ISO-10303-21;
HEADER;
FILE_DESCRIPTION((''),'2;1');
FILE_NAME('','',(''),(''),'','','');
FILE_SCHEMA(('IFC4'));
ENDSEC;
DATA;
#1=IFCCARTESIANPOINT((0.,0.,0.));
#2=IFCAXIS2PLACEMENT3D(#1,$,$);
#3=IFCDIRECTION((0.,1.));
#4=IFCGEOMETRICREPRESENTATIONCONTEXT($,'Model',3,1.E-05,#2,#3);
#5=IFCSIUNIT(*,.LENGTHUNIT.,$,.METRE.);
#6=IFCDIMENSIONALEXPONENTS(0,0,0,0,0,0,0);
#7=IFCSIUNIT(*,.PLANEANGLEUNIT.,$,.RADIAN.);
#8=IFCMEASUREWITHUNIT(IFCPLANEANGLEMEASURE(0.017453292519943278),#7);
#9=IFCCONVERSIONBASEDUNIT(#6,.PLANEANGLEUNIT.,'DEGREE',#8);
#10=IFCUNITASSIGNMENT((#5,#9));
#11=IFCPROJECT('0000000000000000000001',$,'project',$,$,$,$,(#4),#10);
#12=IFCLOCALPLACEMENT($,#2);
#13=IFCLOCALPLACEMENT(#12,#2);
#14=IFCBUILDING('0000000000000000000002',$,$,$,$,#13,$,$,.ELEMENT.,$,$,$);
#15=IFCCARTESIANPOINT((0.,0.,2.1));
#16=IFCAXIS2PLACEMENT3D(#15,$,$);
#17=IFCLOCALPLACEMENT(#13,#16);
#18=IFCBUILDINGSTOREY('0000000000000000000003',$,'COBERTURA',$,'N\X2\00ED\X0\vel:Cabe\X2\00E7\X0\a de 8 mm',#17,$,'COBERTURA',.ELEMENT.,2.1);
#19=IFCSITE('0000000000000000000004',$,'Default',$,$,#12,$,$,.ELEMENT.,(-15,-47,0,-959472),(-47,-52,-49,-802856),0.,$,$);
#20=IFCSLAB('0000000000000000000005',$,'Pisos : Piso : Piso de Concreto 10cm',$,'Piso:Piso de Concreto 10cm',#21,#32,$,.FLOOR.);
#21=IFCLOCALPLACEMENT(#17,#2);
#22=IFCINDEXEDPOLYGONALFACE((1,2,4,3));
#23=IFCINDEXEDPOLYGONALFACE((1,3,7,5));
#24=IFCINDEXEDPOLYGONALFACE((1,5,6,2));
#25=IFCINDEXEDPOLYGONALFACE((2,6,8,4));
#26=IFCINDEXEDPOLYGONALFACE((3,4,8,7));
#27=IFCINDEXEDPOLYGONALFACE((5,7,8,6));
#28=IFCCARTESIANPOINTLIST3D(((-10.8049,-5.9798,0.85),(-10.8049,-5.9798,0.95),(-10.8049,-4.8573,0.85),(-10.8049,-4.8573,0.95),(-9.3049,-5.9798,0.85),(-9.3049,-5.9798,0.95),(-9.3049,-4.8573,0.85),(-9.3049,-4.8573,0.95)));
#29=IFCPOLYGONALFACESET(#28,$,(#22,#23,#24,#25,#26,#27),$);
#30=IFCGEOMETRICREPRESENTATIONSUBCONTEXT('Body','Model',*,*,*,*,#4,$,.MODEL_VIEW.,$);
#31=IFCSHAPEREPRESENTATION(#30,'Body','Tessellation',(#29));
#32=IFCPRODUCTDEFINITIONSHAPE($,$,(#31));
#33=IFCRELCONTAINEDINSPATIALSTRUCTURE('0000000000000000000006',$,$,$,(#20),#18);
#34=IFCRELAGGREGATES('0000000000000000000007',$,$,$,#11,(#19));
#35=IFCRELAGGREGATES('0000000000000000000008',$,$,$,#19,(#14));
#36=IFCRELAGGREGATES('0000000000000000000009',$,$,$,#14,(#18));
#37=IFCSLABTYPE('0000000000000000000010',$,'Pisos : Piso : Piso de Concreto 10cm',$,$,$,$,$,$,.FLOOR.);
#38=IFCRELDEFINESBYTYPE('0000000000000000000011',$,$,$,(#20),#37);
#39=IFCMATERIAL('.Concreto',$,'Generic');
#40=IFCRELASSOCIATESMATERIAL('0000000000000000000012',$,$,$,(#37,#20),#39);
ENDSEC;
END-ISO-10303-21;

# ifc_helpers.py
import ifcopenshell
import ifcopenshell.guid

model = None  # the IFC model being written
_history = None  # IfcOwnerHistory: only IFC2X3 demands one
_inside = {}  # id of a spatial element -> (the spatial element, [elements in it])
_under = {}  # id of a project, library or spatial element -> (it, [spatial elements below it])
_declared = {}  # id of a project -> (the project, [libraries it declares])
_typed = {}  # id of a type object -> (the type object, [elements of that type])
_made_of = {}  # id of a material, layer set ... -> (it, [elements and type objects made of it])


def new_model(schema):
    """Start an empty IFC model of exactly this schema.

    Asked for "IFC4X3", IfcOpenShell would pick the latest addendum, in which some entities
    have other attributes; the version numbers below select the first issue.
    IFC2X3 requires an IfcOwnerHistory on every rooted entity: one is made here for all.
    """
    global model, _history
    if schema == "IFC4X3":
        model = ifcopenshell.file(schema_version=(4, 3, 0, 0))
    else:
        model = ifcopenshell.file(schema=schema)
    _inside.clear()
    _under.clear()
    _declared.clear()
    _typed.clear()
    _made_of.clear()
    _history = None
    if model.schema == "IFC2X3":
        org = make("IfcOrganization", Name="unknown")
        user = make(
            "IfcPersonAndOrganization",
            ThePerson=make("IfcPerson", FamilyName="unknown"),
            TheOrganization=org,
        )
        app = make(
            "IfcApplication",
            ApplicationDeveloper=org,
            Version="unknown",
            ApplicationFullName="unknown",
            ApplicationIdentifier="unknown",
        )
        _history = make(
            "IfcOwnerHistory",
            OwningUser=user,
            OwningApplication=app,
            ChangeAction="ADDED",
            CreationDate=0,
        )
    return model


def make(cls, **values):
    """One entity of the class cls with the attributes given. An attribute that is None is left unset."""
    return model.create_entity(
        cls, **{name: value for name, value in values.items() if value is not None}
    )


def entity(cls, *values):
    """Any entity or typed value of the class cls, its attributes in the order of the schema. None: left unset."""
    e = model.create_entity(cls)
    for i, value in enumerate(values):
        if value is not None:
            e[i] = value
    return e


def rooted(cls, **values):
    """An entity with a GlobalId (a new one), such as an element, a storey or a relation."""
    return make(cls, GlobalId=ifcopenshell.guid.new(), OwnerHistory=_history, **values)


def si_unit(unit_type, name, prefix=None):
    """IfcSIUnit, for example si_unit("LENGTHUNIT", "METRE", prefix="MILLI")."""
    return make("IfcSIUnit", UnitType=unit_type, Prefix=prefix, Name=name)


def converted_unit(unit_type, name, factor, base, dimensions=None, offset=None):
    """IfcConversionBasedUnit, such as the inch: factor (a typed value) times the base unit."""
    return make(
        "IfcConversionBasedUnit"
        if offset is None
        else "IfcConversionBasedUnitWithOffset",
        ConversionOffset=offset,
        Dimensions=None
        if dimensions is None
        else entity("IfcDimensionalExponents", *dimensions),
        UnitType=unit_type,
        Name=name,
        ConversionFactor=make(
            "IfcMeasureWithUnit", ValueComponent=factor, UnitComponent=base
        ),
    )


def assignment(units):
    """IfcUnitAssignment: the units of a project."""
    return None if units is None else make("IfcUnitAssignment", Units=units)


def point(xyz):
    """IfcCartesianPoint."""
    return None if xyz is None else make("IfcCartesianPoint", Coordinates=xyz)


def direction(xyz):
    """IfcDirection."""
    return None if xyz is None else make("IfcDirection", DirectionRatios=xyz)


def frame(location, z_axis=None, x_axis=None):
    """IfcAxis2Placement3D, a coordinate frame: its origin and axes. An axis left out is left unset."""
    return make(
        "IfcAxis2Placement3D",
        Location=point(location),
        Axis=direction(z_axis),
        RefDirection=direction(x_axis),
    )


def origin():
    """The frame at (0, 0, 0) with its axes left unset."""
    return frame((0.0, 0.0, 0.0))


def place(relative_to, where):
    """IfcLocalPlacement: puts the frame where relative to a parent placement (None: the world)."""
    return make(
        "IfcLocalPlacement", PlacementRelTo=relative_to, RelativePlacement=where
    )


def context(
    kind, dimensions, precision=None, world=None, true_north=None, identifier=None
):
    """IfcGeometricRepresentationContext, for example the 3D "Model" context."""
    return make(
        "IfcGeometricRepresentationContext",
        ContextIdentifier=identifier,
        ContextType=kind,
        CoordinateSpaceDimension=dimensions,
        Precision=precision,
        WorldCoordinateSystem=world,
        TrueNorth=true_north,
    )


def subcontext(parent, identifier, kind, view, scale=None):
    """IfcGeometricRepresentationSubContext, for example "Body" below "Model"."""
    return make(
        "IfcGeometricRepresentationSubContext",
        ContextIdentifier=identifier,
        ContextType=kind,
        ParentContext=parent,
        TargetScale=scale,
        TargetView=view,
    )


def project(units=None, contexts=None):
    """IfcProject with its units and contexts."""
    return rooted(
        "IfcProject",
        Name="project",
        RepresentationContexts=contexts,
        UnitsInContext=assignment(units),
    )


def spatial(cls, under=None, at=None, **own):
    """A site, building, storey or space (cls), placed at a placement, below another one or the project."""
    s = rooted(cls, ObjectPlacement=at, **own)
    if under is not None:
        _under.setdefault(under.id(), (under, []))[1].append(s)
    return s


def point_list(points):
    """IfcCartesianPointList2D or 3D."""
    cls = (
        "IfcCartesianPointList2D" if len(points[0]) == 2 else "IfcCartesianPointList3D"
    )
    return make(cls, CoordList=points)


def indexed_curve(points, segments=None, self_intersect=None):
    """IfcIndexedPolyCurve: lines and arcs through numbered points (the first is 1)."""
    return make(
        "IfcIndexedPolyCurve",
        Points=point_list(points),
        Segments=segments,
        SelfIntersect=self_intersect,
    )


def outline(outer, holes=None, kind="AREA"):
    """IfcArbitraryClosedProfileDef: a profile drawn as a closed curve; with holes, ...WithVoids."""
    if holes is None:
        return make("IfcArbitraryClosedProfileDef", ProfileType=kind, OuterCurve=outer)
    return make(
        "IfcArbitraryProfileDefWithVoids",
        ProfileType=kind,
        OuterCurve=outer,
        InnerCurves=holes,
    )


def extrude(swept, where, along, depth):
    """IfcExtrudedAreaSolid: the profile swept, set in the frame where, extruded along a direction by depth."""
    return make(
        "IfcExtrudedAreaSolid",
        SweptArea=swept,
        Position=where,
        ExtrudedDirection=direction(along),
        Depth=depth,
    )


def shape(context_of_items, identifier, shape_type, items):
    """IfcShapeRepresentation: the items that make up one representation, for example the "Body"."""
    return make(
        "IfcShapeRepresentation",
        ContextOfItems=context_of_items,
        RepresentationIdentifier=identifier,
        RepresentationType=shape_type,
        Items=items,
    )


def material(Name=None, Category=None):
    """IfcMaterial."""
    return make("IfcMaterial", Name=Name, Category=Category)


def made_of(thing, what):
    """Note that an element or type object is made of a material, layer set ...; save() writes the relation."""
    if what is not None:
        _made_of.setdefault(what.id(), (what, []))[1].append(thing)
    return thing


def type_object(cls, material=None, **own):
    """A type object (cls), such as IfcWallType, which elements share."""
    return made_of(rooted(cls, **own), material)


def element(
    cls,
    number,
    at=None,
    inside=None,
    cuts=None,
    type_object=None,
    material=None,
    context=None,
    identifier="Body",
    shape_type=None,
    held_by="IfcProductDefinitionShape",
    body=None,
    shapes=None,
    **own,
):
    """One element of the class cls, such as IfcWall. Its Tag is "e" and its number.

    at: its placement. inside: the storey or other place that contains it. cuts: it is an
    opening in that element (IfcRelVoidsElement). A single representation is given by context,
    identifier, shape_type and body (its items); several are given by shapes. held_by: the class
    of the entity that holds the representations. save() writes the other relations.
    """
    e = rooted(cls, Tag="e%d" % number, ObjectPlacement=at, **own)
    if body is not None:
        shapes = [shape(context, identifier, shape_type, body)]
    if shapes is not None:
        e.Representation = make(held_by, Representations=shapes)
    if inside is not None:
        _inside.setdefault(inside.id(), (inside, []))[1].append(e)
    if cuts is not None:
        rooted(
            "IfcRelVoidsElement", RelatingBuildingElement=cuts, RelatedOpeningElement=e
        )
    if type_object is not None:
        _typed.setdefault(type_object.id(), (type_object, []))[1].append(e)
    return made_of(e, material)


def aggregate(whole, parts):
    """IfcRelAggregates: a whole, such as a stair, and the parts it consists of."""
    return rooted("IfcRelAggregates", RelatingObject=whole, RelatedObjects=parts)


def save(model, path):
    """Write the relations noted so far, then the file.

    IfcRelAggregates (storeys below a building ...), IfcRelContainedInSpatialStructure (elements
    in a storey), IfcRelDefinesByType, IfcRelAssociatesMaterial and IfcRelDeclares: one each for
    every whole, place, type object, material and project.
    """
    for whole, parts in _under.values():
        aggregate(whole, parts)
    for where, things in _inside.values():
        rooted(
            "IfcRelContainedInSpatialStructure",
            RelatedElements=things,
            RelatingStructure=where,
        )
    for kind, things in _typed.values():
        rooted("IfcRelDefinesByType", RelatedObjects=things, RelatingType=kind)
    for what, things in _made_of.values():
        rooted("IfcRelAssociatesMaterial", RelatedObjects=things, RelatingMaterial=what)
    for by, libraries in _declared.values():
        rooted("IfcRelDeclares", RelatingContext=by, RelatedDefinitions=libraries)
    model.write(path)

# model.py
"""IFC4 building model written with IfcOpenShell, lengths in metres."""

from ifc_helpers import new_model, entity, si_unit, converted_unit, direction, frame, origin, place, context, subcontext, project, spatial, indexed_curve, outline, extrude, material, type_object, element, save


model = new_model("IFC4")

# Units and contexts
model_context = context("Model", 3, precision=1e-05, world=origin(), true_north=direction((0.0, 1.0)))
body_context = subcontext(model_context, "Body", "Model", "MODEL_VIEW")
ifc_project = project(units=[si_unit("LENGTHUNIT", "METRE"), converted_unit("PLANEANGLEUNIT", "DEGREE", entity("IfcPlaneAngleMeasure", 0.017453292519943278), si_unit("PLANEANGLEUNIT", "RADIAN"), dimensions=[0, 0, 0, 0, 0, 0, 0])], contexts=[model_context])

# Site, building, storey
site_placement = place(None, origin())
site = spatial("IfcSite", under=ifc_project, at=site_placement, Name="Default", CompositionType="ELEMENT", RefLatitude=(-15, -47, 0, -959472), RefLongitude=(-47, -52, -49, -802856), RefElevation=0.0)
building_placement = place(site_placement, origin())
building = spatial("IfcBuilding", under=site, at=building_placement, CompositionType="ELEMENT")
storey_placement = place(building_placement, frame((0.0, 0.0, 2.1)))
storey = spatial("IfcBuildingStorey", under=building, at=storey_placement, Name="COBERTURA", ObjectType="Nível:Cabeça de 8 mm", LongName="COBERTURA", CompositionType="ELEMENT", Elevation=2.1)

# Slab
ifc_material_1 = material(Name=".Concreto", Category="Generic")
slab_type = type_object("IfcSlabType", Name="Pisos : Piso : Piso de Concreto 10cm", PredefinedType="FLOOR", material=ifc_material_1)
slab_placement = place(storey_placement, origin())
element("IfcSlab", 1, at=slab_placement, inside=storey, type_object=slab_type, material=ifc_material_1, Name="Pisos : Piso : Piso de Concreto 10cm", ObjectType="Piso:Piso de Concreto 10cm", PredefinedType="FLOOR", context=body_context, shape_type="SweptSolid", body=[
    extrude(outline(indexed_curve([(-0.5613, -0.75), (0.5613, -0.75), (0.5613, 0.75), (-0.5613, 0.75), (-0.5613, -0.75)], self_intersect=False)), frame((-10.0549, -5.4186, 0.95), z_axis=(0.0, 0.0, -1.0), x_axis=(0.0, 1.0, 0.0)), (0.0, 0.0, 1.0), 0.1),
])

save(model, "model.ifc")
